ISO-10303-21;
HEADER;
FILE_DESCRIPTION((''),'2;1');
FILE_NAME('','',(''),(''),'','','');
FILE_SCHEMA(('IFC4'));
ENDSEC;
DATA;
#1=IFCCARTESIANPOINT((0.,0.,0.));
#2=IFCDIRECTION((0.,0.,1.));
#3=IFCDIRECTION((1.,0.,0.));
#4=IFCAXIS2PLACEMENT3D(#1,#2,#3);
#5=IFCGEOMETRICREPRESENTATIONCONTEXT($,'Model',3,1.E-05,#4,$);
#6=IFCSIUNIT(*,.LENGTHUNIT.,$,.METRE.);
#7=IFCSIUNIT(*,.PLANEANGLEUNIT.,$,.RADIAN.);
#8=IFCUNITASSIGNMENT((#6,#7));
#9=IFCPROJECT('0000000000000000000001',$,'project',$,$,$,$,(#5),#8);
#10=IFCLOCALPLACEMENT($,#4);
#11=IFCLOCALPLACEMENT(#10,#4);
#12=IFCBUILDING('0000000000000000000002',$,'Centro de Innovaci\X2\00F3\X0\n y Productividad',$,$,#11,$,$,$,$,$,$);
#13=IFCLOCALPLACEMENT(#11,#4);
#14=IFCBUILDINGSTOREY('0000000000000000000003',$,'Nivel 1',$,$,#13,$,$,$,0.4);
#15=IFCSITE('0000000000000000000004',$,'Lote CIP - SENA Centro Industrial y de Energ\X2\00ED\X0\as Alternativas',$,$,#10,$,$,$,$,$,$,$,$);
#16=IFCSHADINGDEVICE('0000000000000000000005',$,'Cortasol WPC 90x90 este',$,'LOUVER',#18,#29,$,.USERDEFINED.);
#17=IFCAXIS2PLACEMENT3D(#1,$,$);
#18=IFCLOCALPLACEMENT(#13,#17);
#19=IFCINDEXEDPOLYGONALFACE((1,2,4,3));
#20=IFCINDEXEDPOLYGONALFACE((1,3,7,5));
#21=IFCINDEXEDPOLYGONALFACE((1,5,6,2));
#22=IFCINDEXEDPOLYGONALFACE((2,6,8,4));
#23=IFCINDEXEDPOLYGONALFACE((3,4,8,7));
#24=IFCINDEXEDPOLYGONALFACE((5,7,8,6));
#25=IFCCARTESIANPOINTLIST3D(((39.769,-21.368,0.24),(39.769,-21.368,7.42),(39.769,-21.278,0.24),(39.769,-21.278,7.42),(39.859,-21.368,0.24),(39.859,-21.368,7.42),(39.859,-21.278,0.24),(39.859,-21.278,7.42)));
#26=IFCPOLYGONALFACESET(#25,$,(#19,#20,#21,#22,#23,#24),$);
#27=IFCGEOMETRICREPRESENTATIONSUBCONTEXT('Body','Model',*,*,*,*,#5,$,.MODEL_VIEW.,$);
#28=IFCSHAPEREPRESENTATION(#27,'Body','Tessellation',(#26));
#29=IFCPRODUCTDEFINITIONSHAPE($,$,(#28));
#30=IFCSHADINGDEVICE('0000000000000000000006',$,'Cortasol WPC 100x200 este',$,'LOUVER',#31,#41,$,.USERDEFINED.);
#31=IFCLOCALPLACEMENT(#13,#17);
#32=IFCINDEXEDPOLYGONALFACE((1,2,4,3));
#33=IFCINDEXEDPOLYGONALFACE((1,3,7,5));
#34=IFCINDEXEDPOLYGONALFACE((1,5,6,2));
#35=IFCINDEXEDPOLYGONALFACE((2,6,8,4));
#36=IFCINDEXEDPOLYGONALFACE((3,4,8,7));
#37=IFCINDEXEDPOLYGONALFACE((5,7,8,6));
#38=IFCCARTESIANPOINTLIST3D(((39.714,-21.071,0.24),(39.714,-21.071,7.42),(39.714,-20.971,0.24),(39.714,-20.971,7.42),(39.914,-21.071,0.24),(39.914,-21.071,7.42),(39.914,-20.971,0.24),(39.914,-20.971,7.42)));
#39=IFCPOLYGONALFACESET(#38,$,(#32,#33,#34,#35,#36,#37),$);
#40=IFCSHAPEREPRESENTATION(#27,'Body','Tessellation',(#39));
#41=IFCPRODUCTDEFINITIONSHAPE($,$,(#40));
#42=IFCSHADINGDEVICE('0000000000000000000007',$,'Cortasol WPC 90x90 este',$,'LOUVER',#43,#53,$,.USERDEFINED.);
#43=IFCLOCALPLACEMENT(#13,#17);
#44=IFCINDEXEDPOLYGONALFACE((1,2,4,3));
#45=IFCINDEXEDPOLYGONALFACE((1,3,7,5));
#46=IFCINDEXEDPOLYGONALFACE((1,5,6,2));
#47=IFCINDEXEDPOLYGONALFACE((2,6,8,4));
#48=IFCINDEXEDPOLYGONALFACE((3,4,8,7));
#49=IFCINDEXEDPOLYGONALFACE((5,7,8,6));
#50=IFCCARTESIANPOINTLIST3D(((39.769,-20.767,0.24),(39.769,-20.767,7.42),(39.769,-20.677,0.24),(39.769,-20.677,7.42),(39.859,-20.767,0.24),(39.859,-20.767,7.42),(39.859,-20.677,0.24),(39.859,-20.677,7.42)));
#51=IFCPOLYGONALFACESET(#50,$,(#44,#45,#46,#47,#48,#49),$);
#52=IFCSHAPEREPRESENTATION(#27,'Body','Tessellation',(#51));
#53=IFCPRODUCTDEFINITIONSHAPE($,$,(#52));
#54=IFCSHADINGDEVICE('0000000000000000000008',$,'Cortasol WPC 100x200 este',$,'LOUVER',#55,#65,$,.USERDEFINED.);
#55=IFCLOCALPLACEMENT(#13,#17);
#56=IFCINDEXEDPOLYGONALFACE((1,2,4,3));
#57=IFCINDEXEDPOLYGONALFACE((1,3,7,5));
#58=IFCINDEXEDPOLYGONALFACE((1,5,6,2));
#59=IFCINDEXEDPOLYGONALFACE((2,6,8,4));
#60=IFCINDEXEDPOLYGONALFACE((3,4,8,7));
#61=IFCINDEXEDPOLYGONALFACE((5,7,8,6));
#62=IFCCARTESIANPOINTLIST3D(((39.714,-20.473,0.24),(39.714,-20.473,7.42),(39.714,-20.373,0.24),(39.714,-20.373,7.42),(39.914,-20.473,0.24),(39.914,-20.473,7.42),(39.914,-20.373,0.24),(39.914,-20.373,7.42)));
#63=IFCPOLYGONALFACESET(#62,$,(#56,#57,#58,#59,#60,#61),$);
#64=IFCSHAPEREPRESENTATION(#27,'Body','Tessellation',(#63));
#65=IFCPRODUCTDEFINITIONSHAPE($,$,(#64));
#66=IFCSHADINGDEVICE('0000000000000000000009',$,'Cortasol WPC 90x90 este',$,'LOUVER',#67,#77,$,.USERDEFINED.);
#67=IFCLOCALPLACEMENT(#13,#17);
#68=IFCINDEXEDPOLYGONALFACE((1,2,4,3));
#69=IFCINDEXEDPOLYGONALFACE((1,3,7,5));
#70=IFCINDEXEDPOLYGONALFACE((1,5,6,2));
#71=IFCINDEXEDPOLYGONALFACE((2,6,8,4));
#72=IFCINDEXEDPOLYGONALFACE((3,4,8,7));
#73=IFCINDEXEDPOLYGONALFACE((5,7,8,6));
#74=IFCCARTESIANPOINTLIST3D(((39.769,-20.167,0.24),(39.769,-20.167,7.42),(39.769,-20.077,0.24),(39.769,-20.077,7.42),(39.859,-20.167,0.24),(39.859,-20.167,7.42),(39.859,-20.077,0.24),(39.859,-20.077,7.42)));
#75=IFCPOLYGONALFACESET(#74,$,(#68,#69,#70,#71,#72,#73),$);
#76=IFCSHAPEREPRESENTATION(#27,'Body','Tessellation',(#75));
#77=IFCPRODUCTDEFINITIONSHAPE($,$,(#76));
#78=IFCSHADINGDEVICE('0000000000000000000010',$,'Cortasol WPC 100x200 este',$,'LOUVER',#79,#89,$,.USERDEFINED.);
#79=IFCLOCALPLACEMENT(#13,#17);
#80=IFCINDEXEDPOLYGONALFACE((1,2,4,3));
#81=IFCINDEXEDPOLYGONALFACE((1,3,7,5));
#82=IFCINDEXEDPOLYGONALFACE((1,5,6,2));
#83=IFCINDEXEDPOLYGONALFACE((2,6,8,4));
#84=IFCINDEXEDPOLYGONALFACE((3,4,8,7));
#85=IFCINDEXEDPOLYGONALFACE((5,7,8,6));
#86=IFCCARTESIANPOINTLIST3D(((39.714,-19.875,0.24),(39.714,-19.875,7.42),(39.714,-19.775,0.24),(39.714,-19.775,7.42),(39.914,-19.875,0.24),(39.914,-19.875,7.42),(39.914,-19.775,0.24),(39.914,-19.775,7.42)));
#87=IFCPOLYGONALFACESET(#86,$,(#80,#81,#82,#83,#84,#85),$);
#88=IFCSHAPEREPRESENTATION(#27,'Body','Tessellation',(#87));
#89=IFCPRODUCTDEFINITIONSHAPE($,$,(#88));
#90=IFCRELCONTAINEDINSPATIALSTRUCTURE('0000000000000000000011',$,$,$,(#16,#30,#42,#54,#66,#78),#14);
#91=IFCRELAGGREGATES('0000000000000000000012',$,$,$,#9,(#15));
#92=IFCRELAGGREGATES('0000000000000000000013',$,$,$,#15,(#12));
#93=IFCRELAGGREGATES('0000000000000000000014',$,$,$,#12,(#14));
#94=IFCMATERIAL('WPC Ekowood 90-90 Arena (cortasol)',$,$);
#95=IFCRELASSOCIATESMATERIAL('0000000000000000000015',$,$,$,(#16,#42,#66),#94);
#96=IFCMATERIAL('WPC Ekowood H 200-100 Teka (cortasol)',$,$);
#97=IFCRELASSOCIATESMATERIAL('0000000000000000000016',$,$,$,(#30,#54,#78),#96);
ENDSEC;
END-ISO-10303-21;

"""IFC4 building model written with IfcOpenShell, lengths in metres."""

from ifc_helpers import new_model, si_unit, frame, origin_with_axes, place, context, subcontext, project, spatial, polyline, outline, extrude, material, element, save


model = new_model("IFC4")

# Units and contexts
model_context = context("Model", 3, precision=1e-05, world=origin_with_axes())
body_context = subcontext(model_context, "Body", "Model", "MODEL_VIEW")
ifc_project = project(units=[si_unit("LENGTHUNIT", "METRE"), si_unit("PLANEANGLEUNIT", "RADIAN")], contexts=[model_context])

# Site, building, storey
site_placement = place(None, origin_with_axes())
site = spatial("IfcSite", under=ifc_project, at=site_placement, Name="Lote CIP - SENA Centro Industrial y de Energías Alternativas")
building_placement = place(site_placement, origin_with_axes())
building = spatial("IfcBuilding", under=site, at=building_placement, Name="Centro de Innovación y Productividad")
storey_placement = place(building_placement, origin_with_axes())
storey = spatial("IfcBuildingStorey", under=building, at=storey_placement, Name="Nivel 1", Elevation=0.4)

# Shading devices
ifc_material_1 = material(Name="WPC Ekowood H 200-100 Teka (cortasol)")
ifc_material_2 = material(Name="WPC Ekowood 90-90 Arena (cortasol)")
shading_device_1_placement = place(storey_placement, origin_with_axes())
element("IfcShadingDevice", 1, at=shading_device_1_placement, inside=storey, material=ifc_material_2, Name="Cortasol WPC 90x90 este", ObjectType="LOUVER", PredefinedType="USERDEFINED", context=body_context, shape_type="SweptSolid", body=[
    extrude(outline(polyline([(39.859, -21.368), (39.769, -21.368), (39.769, -21.278), (39.859, -21.278), (39.859, -21.368)])), frame((0.0, 0.0, 0.24)), (0.0, 0.0, 1.0), 7.18),
])
shading_device_2_placement = place(storey_placement, origin_with_axes())
element("IfcShadingDevice", 2, at=shading_device_2_placement, inside=storey, material=ifc_material_1, Name="Cortasol WPC 100x200 este", ObjectType="LOUVER", PredefinedType="USERDEFINED", context=body_context, shape_type="SweptSolid", body=[
    extrude(outline(polyline([(39.914, -21.071), (39.714, -21.071), (39.714, -20.971), (39.914, -20.971), (39.914, -21.071)])), frame((0.0, 0.0, 0.24)), (0.0, 0.0, 1.0), 7.18),
])
shading_device_3_placement = place(storey_placement, origin_with_axes())
element("IfcShadingDevice", 3, at=shading_device_3_placement, inside=storey, material=ifc_material_2, Name="Cortasol WPC 90x90 este", ObjectType="LOUVER", PredefinedType="USERDEFINED", context=body_context, shape_type="SweptSolid", body=[
    extrude(outline(polyline([(39.859, -20.767), (39.769, -20.767), (39.769, -20.677), (39.859, -20.677), (39.859, -20.767)])), frame((0.0, 0.0, 0.24)), (0.0, 0.0, 1.0), 7.18),
])
shading_device_4_placement = place(storey_placement, origin_with_axes())
element("IfcShadingDevice", 4, at=shading_device_4_placement, inside=storey, material=ifc_material_1, Name="Cortasol WPC 100x200 este", ObjectType="LOUVER", PredefinedType="USERDEFINED", context=body_context, shape_type="SweptSolid", body=[
    extrude(outline(polyline([(39.914, -20.473), (39.714, -20.473), (39.714, -20.373), (39.914, -20.373), (39.914, -20.473)])), frame((0.0, 0.0, 0.24)), (0.0, 0.0, 1.0), 7.18),
])
shading_device_5_placement = place(storey_placement, origin_with_axes())
element("IfcShadingDevice", 5, at=shading_device_5_placement, inside=storey, material=ifc_material_2, Name="Cortasol WPC 90x90 este", ObjectType="LOUVER", PredefinedType="USERDEFINED", context=body_context, shape_type="SweptSolid", body=[
    extrude(outline(polyline([(39.859, -20.167), (39.769, -20.167), (39.769, -20.077), (39.859, -20.077), (39.859, -20.167)])), frame((0.0, 0.0, 0.24)), (0.0, 0.0, 1.0), 7.18),
])
shading_device_6_placement = place(storey_placement, origin_with_axes())
element("IfcShadingDevice", 6, at=shading_device_6_placement, inside=storey, material=ifc_material_1, Name="Cortasol WPC 100x200 este", ObjectType="LOUVER", PredefinedType="USERDEFINED", context=body_context, shape_type="SweptSolid", body=[
    extrude(outline(polyline([(39.914, -19.875), (39.714, -19.875), (39.714, -19.775), (39.914, -19.775), (39.914, -19.875)])), frame((0.0, 0.0, 0.24)), (0.0, 0.0, 1.0), 7.18),
])

save(model, "model.ifc")
